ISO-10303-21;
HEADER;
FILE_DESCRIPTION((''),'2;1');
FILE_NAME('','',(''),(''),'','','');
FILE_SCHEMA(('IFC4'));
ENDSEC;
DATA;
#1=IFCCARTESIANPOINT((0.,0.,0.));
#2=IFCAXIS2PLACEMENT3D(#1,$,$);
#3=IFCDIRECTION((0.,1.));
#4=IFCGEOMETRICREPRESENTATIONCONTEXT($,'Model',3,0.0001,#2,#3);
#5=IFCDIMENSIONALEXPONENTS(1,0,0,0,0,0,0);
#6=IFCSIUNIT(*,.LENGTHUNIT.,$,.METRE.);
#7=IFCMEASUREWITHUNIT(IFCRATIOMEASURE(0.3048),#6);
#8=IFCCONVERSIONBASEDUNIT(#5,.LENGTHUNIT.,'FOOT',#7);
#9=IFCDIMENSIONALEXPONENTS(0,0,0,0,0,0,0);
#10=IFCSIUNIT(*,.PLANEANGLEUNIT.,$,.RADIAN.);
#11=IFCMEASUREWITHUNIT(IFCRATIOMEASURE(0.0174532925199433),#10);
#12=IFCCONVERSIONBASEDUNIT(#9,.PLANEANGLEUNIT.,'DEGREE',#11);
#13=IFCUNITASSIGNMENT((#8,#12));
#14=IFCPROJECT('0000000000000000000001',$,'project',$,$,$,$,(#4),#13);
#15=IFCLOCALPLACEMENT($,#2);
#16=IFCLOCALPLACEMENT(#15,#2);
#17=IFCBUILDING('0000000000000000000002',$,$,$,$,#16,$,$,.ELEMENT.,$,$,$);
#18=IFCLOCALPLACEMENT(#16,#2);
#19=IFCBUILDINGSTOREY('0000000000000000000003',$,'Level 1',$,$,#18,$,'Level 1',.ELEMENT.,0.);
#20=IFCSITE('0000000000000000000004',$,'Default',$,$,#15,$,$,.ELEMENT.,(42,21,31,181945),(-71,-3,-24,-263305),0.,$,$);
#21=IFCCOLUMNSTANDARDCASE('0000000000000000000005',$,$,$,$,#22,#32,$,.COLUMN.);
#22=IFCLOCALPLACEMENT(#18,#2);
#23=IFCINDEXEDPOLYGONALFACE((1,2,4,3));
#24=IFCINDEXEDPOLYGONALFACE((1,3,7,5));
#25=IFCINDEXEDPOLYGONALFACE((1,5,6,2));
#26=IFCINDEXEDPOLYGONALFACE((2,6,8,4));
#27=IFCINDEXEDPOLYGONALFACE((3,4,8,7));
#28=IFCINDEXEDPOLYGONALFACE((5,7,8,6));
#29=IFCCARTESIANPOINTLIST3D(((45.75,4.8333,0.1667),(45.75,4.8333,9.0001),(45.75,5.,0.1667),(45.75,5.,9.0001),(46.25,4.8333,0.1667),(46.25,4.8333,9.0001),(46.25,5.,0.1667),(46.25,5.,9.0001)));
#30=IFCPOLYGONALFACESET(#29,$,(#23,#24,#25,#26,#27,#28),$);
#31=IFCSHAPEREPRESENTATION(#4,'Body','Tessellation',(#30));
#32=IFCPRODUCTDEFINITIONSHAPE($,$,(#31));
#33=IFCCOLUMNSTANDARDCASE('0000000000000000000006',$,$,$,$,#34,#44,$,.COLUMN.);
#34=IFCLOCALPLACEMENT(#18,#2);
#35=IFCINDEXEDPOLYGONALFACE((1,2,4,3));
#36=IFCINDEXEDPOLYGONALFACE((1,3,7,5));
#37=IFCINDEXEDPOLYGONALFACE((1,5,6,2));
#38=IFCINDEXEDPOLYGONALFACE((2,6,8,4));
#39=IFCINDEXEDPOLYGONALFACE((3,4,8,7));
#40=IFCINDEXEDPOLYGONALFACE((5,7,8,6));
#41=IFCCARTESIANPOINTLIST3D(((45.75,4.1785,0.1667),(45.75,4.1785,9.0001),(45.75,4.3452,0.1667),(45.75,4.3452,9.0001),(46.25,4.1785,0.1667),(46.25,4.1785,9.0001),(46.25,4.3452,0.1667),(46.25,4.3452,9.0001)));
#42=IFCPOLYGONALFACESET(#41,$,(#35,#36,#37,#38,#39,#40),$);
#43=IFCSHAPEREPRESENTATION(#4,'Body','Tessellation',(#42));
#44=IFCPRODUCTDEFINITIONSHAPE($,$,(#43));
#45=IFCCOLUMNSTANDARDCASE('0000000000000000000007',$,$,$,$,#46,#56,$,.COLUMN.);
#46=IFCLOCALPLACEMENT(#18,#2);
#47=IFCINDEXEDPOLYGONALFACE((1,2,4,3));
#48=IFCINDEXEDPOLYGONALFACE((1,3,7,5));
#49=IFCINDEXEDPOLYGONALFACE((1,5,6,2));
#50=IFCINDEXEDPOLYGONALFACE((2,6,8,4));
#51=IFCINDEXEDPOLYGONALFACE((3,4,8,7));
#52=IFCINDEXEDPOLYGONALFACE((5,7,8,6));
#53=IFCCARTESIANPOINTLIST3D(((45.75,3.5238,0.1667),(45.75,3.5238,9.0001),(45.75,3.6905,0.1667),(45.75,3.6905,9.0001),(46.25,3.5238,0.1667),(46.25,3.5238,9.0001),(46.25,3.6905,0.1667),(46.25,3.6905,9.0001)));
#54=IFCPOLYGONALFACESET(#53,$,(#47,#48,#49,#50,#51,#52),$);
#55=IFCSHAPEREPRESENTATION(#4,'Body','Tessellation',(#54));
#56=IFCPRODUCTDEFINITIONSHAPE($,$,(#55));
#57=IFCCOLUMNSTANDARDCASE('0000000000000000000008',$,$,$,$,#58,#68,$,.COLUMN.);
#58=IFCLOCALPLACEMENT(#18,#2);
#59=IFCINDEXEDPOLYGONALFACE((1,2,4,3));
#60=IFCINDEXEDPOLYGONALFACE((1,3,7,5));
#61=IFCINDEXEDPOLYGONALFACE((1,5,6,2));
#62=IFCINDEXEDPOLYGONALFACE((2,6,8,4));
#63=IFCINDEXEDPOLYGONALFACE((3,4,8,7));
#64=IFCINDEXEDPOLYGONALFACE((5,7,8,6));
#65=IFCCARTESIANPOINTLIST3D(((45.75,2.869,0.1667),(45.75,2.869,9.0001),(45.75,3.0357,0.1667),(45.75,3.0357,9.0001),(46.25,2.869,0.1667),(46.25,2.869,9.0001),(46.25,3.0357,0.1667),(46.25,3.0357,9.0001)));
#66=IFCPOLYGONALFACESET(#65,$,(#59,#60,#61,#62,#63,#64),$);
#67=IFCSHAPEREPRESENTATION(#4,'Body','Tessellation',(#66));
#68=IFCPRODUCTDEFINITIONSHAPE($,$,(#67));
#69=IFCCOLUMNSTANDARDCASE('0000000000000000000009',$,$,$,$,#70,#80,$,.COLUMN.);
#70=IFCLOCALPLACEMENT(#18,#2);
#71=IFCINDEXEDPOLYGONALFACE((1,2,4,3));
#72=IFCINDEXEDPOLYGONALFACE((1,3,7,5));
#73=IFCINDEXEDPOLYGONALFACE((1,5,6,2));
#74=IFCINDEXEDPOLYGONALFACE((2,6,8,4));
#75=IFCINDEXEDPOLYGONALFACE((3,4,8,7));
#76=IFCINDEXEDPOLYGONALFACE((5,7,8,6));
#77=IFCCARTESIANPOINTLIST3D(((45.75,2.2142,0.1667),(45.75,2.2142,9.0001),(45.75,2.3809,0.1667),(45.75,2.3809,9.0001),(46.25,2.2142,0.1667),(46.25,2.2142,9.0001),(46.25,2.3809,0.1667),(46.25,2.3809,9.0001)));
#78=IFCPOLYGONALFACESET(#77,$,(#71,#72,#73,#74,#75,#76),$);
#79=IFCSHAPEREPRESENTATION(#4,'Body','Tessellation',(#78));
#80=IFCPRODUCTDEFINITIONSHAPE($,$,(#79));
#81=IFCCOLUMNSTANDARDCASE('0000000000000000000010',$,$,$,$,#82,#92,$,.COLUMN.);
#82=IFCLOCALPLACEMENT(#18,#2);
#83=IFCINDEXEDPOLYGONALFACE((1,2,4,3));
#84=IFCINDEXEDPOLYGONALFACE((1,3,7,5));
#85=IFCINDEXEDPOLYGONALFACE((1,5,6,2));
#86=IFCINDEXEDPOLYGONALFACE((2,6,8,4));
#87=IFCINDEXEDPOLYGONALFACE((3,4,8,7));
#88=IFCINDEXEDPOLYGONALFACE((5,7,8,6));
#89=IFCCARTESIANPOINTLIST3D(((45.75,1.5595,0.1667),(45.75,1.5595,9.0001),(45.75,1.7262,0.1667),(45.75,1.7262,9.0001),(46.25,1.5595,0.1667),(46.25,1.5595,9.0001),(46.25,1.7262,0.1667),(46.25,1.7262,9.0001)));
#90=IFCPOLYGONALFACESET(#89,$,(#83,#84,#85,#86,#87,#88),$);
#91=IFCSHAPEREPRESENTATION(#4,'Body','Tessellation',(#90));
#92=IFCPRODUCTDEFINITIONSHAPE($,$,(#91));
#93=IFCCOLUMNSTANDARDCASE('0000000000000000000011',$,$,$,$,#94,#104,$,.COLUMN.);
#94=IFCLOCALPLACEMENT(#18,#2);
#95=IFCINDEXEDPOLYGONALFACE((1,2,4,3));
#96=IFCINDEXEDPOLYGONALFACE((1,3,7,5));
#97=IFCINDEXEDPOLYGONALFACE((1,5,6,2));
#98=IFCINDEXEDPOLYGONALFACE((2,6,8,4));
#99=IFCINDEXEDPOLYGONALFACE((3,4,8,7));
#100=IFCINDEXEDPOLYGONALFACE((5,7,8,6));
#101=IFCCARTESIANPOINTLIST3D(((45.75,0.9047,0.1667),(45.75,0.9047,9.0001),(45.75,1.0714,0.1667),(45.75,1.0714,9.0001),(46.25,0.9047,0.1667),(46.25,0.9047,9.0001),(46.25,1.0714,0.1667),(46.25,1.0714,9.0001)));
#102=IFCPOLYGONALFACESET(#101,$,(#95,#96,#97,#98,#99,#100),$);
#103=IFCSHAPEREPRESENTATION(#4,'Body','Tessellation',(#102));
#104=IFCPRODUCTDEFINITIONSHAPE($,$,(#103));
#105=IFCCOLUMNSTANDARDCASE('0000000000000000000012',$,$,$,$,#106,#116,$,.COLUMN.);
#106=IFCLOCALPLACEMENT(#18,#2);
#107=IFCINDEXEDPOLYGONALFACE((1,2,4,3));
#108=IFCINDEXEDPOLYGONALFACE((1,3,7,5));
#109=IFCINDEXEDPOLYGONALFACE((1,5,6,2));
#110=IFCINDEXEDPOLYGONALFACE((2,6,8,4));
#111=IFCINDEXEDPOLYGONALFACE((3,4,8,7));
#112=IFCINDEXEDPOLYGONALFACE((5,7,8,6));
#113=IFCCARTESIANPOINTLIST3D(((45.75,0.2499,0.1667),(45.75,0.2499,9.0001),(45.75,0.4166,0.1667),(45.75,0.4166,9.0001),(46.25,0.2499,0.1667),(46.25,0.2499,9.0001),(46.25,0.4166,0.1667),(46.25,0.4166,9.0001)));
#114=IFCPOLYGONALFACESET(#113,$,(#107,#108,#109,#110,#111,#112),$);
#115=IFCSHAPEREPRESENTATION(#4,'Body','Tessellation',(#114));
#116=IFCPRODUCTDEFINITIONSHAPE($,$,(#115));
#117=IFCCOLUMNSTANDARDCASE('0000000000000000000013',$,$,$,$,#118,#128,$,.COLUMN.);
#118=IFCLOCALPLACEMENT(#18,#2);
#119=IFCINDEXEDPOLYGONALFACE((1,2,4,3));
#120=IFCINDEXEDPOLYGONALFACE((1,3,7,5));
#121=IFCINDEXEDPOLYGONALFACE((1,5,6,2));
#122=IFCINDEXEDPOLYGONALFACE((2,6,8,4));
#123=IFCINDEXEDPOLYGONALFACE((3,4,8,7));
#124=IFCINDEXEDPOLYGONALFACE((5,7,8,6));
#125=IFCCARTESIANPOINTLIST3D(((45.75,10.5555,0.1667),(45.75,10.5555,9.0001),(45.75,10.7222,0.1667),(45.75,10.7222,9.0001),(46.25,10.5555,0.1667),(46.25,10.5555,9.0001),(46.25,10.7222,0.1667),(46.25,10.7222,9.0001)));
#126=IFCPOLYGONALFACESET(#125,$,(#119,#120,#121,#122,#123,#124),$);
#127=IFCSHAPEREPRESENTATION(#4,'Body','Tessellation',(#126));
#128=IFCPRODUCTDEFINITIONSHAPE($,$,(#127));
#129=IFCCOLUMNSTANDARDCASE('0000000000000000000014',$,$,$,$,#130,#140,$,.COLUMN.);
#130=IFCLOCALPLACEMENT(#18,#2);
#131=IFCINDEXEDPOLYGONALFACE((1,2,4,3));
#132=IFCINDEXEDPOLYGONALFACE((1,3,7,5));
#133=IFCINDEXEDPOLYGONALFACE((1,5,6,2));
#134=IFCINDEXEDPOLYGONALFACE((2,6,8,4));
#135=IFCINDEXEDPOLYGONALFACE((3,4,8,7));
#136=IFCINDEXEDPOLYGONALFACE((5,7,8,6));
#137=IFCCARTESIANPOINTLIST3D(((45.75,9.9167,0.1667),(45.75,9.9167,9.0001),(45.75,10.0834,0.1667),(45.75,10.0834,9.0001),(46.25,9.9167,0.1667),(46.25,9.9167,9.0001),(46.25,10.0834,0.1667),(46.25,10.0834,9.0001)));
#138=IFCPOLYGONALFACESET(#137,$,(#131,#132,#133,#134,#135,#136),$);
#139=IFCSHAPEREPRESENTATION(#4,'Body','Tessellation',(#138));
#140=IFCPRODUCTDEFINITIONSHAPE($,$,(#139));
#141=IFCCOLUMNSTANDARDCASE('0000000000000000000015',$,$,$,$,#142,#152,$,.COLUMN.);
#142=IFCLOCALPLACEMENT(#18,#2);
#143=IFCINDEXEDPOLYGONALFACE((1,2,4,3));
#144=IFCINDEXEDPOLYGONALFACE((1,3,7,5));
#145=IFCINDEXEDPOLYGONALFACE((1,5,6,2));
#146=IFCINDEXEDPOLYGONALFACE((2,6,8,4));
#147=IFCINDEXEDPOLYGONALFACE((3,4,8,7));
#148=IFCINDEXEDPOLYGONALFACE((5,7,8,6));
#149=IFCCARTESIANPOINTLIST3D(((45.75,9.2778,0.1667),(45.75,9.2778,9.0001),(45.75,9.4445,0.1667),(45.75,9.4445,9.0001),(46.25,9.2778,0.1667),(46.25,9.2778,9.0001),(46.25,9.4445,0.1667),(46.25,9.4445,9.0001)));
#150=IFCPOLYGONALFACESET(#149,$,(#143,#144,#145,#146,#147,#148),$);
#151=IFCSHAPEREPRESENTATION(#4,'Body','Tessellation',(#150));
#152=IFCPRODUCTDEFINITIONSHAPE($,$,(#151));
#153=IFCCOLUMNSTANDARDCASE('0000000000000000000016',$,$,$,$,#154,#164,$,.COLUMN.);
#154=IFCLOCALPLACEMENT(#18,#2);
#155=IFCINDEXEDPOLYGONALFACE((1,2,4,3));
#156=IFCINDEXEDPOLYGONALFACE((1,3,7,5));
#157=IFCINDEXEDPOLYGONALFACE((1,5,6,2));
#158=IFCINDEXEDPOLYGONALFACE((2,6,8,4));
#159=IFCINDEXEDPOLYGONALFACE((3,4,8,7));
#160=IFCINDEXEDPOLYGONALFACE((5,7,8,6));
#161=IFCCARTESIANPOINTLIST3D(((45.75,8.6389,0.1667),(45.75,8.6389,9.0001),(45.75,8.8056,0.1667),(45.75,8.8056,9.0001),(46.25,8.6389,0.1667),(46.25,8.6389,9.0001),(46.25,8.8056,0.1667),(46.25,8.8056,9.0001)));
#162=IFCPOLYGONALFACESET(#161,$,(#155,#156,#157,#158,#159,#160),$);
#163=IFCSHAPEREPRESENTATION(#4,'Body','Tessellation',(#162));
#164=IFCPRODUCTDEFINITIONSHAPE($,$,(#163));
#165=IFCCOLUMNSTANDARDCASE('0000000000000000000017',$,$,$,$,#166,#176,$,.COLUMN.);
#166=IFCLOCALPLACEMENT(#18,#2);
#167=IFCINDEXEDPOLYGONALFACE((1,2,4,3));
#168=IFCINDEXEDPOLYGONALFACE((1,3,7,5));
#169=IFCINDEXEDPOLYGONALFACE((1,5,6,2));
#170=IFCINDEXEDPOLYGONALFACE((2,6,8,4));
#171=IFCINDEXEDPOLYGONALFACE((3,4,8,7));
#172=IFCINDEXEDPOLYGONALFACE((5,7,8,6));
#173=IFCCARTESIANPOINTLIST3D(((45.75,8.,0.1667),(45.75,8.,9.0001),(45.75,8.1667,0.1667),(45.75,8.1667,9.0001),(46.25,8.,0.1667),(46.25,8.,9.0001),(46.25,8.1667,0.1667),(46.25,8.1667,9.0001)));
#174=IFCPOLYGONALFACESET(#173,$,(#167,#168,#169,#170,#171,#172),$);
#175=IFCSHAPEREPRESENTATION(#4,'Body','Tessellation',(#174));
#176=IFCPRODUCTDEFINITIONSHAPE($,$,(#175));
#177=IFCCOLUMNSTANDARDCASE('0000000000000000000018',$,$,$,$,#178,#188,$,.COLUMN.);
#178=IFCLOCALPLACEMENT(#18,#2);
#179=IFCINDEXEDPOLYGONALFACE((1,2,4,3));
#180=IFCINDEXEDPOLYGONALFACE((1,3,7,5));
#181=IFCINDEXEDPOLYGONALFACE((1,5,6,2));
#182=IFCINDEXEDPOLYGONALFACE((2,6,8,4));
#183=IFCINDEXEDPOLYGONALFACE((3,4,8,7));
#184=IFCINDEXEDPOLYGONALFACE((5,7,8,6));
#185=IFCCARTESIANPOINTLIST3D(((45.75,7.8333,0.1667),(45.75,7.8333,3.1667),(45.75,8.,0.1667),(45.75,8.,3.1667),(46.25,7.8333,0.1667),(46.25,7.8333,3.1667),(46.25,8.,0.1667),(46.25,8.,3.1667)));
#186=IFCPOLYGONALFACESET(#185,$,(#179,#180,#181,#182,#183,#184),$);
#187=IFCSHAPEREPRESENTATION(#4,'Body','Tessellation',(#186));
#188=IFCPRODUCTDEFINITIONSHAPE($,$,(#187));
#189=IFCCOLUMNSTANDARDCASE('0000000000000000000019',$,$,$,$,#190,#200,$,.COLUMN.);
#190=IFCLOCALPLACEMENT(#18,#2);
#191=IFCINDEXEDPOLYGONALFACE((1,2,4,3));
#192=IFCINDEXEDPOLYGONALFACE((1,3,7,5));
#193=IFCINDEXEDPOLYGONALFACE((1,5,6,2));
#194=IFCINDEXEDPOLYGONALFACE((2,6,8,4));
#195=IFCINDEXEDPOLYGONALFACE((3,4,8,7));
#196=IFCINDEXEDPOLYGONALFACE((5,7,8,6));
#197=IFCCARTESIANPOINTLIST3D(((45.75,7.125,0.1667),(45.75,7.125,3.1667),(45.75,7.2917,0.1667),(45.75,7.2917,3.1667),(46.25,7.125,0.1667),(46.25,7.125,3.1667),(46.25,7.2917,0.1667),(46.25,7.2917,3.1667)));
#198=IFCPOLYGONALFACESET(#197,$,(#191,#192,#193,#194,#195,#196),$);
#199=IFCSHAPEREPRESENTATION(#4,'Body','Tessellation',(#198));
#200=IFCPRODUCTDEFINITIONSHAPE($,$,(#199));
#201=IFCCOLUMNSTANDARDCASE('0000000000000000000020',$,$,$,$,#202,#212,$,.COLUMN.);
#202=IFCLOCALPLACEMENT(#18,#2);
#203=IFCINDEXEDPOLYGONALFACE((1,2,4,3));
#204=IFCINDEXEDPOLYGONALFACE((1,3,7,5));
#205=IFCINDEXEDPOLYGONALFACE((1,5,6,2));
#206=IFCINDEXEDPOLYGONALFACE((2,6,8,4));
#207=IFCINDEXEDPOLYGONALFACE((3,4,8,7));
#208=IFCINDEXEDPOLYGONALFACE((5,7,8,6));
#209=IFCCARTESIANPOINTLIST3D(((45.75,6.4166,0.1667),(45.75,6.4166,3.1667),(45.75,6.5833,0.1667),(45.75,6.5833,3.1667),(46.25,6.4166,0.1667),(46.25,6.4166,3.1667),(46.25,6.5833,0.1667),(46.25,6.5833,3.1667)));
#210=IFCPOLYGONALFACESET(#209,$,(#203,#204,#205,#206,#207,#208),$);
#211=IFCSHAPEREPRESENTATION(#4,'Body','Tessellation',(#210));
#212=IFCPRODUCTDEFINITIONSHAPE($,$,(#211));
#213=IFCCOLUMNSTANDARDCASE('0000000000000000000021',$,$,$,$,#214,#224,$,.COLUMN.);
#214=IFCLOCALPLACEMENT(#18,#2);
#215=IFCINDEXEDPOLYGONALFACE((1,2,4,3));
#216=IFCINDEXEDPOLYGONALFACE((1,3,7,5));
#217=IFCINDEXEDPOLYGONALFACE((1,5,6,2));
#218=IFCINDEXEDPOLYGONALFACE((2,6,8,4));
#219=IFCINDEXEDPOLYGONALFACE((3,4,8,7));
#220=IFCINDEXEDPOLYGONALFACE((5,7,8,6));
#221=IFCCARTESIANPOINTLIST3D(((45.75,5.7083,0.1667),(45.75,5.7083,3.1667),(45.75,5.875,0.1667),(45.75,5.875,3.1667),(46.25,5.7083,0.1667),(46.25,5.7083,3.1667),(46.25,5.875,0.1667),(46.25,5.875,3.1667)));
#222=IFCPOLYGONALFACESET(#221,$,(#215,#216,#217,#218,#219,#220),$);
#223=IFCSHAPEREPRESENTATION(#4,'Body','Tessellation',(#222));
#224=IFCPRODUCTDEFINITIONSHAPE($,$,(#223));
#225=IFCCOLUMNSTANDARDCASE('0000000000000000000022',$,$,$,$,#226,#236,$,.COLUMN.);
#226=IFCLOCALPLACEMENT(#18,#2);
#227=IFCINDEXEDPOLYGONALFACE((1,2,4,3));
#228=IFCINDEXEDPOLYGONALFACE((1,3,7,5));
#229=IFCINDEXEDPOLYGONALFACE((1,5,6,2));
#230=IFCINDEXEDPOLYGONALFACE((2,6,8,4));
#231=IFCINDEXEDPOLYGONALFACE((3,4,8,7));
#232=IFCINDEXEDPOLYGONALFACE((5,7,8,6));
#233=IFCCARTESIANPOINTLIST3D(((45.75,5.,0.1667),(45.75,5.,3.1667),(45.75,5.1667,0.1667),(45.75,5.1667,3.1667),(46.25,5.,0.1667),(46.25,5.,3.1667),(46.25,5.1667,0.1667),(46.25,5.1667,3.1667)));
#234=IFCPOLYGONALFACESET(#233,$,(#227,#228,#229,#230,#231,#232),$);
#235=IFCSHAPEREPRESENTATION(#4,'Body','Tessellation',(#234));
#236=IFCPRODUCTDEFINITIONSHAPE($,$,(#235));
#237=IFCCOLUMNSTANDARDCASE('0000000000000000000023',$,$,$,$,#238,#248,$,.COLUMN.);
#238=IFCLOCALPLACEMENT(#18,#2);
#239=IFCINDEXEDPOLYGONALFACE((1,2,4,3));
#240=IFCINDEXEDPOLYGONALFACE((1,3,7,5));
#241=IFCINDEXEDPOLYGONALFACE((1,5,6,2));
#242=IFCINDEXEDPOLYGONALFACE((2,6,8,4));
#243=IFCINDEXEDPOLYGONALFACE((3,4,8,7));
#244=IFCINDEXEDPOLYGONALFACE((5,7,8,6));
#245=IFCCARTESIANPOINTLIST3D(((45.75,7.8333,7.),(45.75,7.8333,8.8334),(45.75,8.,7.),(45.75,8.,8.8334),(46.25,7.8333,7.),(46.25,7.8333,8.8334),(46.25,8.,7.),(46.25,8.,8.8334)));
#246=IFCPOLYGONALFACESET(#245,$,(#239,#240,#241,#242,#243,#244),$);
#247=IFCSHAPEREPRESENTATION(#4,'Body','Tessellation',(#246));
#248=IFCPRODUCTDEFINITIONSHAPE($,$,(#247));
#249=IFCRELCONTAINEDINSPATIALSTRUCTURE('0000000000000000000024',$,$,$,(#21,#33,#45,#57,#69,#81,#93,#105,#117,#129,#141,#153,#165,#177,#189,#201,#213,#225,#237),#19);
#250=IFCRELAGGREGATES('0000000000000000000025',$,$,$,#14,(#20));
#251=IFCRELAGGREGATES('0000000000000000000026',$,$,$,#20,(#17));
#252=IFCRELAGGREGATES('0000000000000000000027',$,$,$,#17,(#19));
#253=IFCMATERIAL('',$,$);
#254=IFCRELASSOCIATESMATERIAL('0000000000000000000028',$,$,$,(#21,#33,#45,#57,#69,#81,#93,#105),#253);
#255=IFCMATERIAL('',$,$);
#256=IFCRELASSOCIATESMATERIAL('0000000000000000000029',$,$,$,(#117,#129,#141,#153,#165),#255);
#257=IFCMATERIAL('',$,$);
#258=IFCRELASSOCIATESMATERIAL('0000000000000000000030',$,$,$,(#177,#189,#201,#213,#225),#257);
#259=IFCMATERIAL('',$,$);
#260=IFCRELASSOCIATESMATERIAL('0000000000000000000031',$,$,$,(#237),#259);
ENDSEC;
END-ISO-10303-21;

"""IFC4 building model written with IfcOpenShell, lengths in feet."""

from ifc_helpers import new_model, entity, si_unit, converted_unit, direction, frame, origin, place, context, project, spatial, rectangle, extrude, material, element, save


model = new_model("IFC4")

# Units and contexts
model_context = context("Model", 3, precision=0.0001, world=origin(), true_north=direction((0.0, 1.0)))
ifc_project = project(units=[converted_unit("LENGTHUNIT", "FOOT", entity("IfcRatioMeasure", 0.3048), si_unit("LENGTHUNIT", "METRE"), dimensions=[1, 0, 0, 0, 0, 0, 0]), converted_unit("PLANEANGLEUNIT", "DEGREE", entity("IfcRatioMeasure", 0.0174532925199433), si_unit("PLANEANGLEUNIT", "RADIAN"), dimensions=[0, 0, 0, 0, 0, 0, 0])], contexts=[model_context])

# Site, building, storey
site_placement = place(None, origin())
site = spatial("IfcSite", under=ifc_project, at=site_placement, Name="Default", CompositionType="ELEMENT", RefLatitude=(42, 21, 31, 181945), RefLongitude=(-71, -3, -24, -263305), RefElevation=0.0)
building_placement = place(site_placement, origin())
building = spatial("IfcBuilding", under=site, at=building_placement, CompositionType="ELEMENT")
storey_placement = place(building_placement, origin())
storey = spatial("IfcBuildingStorey", under=building, at=storey_placement, Name="Level 1", LongName="Level 1", CompositionType="ELEMENT", Elevation=0.0)

# Columns
ifc_material_1 = material(Name="")
placement_1 = place(storey_placement, frame((46.0, 46.25, 0.0), z_axis=(0.0, 0.0, 1.0), x_axis=(0.0, -1.0, 0.0)))
for number, where, z_axis, x_axis in (
    (1, (41.3334, 0.0, 0.1667), (0.0, 0.0, 1.0), (1.0, 0.0, 0.0)),
    (2, (41.9882, 0.0, 0.1667), (0.0, 0.0, 1.0), (1.0, 0.0, 0.0)),
    (3, (42.6429, 0.0, 0.1667), (0.0, 0.0, 1.0), (1.0, 0.0, 0.0)),
    (4, (43.2977, 0.0, 0.1667), (0.0, 0.0, 1.0), (1.0, 0.0, 0.0)),
    (5, (43.9525, 0.0, 0.1667), (0.0, 0.0, 1.0), (1.0, 0.0, 0.0)),
    (6, (44.6072, 0.0, 0.1667), (0.0, 0.0, 1.0), (1.0, 0.0, 0.0)),
    (7, (45.262, 0.0, 0.1667), (0.0, 0.0, 1.0), (1.0, 0.0, 0.0)),
    (8, (45.9168, 0.0, 0.1667), (0.0, 0.0, 1.0), (1.0, 0.0, 0.0)),
):
    element("IfcColumnStandardCase", number, at=place(placement_1, frame(where, z_axis=z_axis, x_axis=x_axis)), inside=storey, material=ifc_material_1, PredefinedType="COLUMN", context=model_context, shape_type="SweptSolid", body=[
        extrude(rectangle(XDim=0.1667, YDim=0.5), origin(), (0.0, 0.0, 1.0), 8.8334),
    ])
ifc_material_2 = material(Name="")
for number, where, z_axis, x_axis in (
    (9, (35.6112, 0.0, 0.1667), (0.0, 0.0, 1.0), (1.0, 0.0, 0.0)),
    (10, (36.25, 0.0, 0.1667), (0.0, 0.0, 1.0), (1.0, 0.0, 0.0)),
    (11, (36.8889, 0.0, 0.1667), (0.0, 0.0, 1.0), (1.0, 0.0, 0.0)),
    (12, (37.5278, 0.0, 0.1667), (0.0, 0.0, 1.0), (1.0, 0.0, 0.0)),
    (13, (38.1667, 0.0, 0.1667), (0.0, 0.0, 1.0), (1.0, 0.0, 0.0)),
):
    element("IfcColumnStandardCase", number, at=place(placement_1, frame(where, z_axis=z_axis, x_axis=x_axis)), inside=storey, material=ifc_material_2, PredefinedType="COLUMN", context=model_context, shape_type="SweptSolid", body=[
        extrude(rectangle(XDim=0.1667, YDim=0.5), origin(), (0.0, 0.0, 1.0), 8.8334),
    ])
ifc_material_3 = material(Name="")
for number, where, z_axis, x_axis in (
    (14, (38.3334, 0.0, 0.1667), (0.0, 0.0, 1.0), (1.0, 0.0, 0.0)),
    (15, (39.0417, 0.0, 0.1667), (0.0, 0.0, 1.0), (1.0, 0.0, 0.0)),
    (16, (39.7501, 0.0, 0.1667), (0.0, 0.0, 1.0), (1.0, 0.0, 0.0)),
    (17, (40.4584, 0.0, 0.1667), (0.0, 0.0, 1.0), (1.0, 0.0, 0.0)),
    (18, (41.1667, 0.0, 0.1667), (0.0, 0.0, 1.0), (1.0, 0.0, 0.0)),
):
    element("IfcColumnStandardCase", number, at=place(placement_1, frame(where, z_axis=z_axis, x_axis=x_axis)), inside=storey, material=ifc_material_3, PredefinedType="COLUMN", context=model_context, shape_type="SweptSolid", body=[
        extrude(rectangle(XDim=0.1667, YDim=0.5), origin(), (0.0, 0.0, 1.0), 3.0),
    ])
ifc_material_4 = material(Name="")
for number, where, z_axis, x_axis in (
    (19, (38.3334, 0.0, 7.0), (0.0, 0.0, 1.0), (1.0, 0.0, 0.0)),
):
    element("IfcColumnStandardCase", number, at=place(placement_1, frame(where, z_axis=z_axis, x_axis=x_axis)), inside=storey, material=ifc_material_4, PredefinedType="COLUMN", context=model_context, shape_type="SweptSolid", body=[
        extrude(rectangle(XDim=0.1667, YDim=0.5), origin(), (0.0, 0.0, 1.0), 1.8334),
    ])

save(model, "model.ifc")
